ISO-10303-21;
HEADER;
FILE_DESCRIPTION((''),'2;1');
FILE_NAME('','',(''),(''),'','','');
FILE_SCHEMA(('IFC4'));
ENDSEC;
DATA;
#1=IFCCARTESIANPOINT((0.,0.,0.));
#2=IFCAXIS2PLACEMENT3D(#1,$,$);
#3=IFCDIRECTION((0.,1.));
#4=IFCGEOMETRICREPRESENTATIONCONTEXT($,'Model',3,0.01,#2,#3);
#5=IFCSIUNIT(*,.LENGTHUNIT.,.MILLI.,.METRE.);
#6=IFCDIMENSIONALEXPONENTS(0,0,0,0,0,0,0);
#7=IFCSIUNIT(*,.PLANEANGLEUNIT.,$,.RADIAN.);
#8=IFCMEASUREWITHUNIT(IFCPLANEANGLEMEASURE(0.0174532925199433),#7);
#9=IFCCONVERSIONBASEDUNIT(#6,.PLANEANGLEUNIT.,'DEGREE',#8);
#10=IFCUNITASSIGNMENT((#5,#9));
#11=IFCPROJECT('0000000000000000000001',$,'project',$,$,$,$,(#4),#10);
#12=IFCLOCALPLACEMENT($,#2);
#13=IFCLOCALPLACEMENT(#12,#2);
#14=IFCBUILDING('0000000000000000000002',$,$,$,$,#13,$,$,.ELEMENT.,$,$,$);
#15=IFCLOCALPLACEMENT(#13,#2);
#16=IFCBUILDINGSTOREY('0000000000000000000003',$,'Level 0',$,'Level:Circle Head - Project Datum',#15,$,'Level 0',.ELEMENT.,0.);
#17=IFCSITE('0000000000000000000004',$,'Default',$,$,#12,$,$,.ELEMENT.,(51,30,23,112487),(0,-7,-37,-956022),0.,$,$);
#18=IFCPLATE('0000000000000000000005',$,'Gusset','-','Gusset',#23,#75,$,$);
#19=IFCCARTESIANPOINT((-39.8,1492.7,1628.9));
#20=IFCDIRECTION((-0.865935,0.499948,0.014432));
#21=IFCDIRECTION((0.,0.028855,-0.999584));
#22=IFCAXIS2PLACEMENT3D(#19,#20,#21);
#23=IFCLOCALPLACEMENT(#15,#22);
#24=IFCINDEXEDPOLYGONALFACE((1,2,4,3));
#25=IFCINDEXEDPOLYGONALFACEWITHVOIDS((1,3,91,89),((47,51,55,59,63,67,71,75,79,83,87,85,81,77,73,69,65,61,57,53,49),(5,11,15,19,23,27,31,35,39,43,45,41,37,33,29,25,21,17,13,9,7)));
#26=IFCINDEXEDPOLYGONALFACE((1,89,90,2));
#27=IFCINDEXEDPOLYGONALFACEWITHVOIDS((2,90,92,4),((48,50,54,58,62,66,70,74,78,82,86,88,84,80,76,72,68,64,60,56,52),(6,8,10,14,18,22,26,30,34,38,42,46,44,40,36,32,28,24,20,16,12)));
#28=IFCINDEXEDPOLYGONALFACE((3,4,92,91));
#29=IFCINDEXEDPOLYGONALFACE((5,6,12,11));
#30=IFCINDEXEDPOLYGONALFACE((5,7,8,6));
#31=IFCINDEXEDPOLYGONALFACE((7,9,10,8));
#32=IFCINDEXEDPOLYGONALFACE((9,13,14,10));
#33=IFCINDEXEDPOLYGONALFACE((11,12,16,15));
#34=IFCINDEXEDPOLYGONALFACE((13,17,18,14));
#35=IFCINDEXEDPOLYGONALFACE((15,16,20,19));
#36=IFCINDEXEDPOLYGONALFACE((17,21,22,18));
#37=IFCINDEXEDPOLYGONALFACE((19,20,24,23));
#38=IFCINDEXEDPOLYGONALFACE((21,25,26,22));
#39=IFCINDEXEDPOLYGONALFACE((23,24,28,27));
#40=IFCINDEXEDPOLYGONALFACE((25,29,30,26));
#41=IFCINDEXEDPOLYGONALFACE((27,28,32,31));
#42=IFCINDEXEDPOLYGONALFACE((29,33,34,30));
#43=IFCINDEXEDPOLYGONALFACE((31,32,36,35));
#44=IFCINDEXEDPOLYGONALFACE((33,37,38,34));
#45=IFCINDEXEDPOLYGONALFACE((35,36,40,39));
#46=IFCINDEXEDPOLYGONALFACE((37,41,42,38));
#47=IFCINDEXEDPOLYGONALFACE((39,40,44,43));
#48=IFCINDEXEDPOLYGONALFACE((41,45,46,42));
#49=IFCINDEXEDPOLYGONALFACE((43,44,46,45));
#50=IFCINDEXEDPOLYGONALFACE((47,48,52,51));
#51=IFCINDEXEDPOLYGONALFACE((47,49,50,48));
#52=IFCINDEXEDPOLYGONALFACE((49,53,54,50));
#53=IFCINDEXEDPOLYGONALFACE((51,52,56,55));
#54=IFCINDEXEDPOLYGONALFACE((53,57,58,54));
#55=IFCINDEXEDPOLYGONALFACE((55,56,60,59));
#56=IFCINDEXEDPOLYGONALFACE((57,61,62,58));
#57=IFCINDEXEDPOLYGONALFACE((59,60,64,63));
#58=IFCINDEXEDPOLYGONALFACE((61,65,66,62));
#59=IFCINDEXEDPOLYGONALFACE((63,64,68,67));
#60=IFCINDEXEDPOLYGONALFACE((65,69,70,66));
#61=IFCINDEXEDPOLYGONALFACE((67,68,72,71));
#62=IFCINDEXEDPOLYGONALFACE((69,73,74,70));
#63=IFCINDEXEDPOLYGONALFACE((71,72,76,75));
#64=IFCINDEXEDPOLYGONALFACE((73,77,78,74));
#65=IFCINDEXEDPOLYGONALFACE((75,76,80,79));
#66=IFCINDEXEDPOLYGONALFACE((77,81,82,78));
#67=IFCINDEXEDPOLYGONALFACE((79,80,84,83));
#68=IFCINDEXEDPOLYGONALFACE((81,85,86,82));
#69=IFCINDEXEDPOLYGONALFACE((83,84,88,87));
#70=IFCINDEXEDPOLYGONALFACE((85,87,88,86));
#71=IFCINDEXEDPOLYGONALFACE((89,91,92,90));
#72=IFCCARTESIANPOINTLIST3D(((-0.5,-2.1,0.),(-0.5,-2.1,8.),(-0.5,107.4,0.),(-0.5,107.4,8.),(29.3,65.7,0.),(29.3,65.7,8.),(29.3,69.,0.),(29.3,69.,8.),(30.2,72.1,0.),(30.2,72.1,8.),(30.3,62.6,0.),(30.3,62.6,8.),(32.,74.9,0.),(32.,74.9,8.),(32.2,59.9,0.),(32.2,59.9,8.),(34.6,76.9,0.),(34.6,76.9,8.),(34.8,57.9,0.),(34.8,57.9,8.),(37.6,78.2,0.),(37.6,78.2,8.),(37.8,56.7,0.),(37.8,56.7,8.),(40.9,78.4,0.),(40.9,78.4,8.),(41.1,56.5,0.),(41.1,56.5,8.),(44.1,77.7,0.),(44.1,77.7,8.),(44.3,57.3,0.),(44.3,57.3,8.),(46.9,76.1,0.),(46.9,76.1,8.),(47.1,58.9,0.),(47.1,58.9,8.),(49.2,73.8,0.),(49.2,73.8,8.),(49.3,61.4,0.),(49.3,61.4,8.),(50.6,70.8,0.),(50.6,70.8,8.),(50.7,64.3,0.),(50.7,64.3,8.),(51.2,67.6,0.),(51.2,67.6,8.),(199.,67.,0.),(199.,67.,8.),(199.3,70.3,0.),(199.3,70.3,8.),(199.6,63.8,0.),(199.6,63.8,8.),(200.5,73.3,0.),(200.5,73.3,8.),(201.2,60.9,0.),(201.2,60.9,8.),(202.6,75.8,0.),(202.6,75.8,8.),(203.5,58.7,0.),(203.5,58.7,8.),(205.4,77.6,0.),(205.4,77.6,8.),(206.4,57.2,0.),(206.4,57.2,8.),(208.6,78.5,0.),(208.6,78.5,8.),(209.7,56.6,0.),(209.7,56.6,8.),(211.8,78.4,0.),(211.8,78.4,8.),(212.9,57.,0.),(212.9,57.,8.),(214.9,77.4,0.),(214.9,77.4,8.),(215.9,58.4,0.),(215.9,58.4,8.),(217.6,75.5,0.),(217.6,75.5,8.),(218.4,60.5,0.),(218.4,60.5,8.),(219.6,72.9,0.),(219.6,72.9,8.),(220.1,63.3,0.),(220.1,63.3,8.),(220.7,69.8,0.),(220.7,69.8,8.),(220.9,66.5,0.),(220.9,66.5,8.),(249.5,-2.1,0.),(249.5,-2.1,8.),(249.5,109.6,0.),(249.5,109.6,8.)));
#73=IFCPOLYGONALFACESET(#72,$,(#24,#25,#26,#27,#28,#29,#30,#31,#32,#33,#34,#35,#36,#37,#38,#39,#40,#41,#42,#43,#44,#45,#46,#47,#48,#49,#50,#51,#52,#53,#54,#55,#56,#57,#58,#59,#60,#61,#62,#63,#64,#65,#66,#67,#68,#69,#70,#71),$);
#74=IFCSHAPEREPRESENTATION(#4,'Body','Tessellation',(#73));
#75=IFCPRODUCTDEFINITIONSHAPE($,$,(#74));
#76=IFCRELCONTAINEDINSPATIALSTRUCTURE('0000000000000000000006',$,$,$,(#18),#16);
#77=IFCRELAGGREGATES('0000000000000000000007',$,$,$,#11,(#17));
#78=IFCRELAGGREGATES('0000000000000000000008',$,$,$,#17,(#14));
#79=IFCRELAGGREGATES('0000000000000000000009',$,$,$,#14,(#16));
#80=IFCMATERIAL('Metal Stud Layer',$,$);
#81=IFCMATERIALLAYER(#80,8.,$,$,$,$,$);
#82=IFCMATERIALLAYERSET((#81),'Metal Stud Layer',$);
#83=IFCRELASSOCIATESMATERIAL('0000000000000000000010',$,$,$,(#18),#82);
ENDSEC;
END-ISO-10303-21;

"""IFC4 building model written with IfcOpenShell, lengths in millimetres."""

from ifc_helpers import new_model, entity, si_unit, converted_unit, direction, frame, origin, origin_with_axes, origin_2d_with_axis, place, context, project, spatial, polyline, circle, outline, extrude, material, layer, layer_set, element, save


model = new_model("IFC4")

# Units and contexts
model_context = context("Model", 3, precision=0.01, world=origin(), true_north=direction((0.0, 1.0)))
ifc_project = project(units=[si_unit("LENGTHUNIT", "METRE", prefix="MILLI"), converted_unit("PLANEANGLEUNIT", "DEGREE", entity("IfcPlaneAngleMeasure", 0.0174532925199433), si_unit("PLANEANGLEUNIT", "RADIAN"), dimensions=[0, 0, 0, 0, 0, 0, 0])], contexts=[model_context])

# Site, building, storey
site_placement = place(None, origin())
site = spatial("IfcSite", under=ifc_project, at=site_placement, Name="Default", CompositionType="ELEMENT", RefLatitude=(51, 30, 23, 112487), RefLongitude=(0, -7, -37, -956022), RefElevation=0.0)
building_placement = place(site_placement, origin())
building = spatial("IfcBuilding", under=site, at=building_placement, CompositionType="ELEMENT")
storey_placement = place(building_placement, origin())
storey = spatial("IfcBuildingStorey", under=building, at=storey_placement, Name="Level 0", ObjectType="Level:Circle Head - Project Datum", LongName="Level 0", CompositionType="ELEMENT", Elevation=0.0)

# Plate, openings
ifc_material = material(Name="Metal Stud Layer")
ifc_layer_1 = layer(ifc_material, 8.0)
ifc_layer_set_1 = layer_set([ifc_layer_1], Name="Metal Stud Layer")
plate_1_placement = place(storey_placement, frame((-39.8, 1492.7, 1628.9), z_axis=(-0.865935, 0.499948, 0.014432), x_axis=(0.0, 0.028855, -0.999584)))
plate_1 = element("IfcPlate", 1, at=plate_1_placement, inside=storey, material=ifc_layer_set_1, Name="Gusset", Description="-", ObjectType="Gusset", context=model_context, shape_type="SweptSolid", body=[
    extrude(outline(polyline([(-0.5, -2.1), (249.5, -2.1), (249.5, 109.6), (-0.5, 107.4), (-0.5, -2.1)])), origin_with_axes(), (0.0, 0.0, 1.0), 8.0),
])
opening_1_placement = place(plate_1_placement, frame((40.2, 67.5, 8.5), z_axis=(0.0, 0.0, -1.0), x_axis=(-0.509076, 0.860722, 0.0)))
element("IfcOpeningElement", 2, at=opening_1_placement, cuts=plate_1, ObjectType="Opening", context=model_context, shape_type="SweptSolid", body=[
    extrude(circle(Radius=11.0, at=origin_2d_with_axis()), origin(), (0.0, 0.0, 1.0), 9.0),
])
opening_2_placement = place(plate_1_placement, frame((209.9, 67.6, 8.5), z_axis=(0.0, 0.0, -1.0), x_axis=(0.455098, 0.890441, 0.0)))
element("IfcOpeningElement", 3, at=opening_2_placement, cuts=plate_1, ObjectType="Opening", context=model_context, shape_type="SweptSolid", body=[
    extrude(circle(Radius=11.0, at=origin_2d_with_axis()), origin(), (0.0, 0.0, 1.0), 9.0),
])

save(model, "model.ifc")
